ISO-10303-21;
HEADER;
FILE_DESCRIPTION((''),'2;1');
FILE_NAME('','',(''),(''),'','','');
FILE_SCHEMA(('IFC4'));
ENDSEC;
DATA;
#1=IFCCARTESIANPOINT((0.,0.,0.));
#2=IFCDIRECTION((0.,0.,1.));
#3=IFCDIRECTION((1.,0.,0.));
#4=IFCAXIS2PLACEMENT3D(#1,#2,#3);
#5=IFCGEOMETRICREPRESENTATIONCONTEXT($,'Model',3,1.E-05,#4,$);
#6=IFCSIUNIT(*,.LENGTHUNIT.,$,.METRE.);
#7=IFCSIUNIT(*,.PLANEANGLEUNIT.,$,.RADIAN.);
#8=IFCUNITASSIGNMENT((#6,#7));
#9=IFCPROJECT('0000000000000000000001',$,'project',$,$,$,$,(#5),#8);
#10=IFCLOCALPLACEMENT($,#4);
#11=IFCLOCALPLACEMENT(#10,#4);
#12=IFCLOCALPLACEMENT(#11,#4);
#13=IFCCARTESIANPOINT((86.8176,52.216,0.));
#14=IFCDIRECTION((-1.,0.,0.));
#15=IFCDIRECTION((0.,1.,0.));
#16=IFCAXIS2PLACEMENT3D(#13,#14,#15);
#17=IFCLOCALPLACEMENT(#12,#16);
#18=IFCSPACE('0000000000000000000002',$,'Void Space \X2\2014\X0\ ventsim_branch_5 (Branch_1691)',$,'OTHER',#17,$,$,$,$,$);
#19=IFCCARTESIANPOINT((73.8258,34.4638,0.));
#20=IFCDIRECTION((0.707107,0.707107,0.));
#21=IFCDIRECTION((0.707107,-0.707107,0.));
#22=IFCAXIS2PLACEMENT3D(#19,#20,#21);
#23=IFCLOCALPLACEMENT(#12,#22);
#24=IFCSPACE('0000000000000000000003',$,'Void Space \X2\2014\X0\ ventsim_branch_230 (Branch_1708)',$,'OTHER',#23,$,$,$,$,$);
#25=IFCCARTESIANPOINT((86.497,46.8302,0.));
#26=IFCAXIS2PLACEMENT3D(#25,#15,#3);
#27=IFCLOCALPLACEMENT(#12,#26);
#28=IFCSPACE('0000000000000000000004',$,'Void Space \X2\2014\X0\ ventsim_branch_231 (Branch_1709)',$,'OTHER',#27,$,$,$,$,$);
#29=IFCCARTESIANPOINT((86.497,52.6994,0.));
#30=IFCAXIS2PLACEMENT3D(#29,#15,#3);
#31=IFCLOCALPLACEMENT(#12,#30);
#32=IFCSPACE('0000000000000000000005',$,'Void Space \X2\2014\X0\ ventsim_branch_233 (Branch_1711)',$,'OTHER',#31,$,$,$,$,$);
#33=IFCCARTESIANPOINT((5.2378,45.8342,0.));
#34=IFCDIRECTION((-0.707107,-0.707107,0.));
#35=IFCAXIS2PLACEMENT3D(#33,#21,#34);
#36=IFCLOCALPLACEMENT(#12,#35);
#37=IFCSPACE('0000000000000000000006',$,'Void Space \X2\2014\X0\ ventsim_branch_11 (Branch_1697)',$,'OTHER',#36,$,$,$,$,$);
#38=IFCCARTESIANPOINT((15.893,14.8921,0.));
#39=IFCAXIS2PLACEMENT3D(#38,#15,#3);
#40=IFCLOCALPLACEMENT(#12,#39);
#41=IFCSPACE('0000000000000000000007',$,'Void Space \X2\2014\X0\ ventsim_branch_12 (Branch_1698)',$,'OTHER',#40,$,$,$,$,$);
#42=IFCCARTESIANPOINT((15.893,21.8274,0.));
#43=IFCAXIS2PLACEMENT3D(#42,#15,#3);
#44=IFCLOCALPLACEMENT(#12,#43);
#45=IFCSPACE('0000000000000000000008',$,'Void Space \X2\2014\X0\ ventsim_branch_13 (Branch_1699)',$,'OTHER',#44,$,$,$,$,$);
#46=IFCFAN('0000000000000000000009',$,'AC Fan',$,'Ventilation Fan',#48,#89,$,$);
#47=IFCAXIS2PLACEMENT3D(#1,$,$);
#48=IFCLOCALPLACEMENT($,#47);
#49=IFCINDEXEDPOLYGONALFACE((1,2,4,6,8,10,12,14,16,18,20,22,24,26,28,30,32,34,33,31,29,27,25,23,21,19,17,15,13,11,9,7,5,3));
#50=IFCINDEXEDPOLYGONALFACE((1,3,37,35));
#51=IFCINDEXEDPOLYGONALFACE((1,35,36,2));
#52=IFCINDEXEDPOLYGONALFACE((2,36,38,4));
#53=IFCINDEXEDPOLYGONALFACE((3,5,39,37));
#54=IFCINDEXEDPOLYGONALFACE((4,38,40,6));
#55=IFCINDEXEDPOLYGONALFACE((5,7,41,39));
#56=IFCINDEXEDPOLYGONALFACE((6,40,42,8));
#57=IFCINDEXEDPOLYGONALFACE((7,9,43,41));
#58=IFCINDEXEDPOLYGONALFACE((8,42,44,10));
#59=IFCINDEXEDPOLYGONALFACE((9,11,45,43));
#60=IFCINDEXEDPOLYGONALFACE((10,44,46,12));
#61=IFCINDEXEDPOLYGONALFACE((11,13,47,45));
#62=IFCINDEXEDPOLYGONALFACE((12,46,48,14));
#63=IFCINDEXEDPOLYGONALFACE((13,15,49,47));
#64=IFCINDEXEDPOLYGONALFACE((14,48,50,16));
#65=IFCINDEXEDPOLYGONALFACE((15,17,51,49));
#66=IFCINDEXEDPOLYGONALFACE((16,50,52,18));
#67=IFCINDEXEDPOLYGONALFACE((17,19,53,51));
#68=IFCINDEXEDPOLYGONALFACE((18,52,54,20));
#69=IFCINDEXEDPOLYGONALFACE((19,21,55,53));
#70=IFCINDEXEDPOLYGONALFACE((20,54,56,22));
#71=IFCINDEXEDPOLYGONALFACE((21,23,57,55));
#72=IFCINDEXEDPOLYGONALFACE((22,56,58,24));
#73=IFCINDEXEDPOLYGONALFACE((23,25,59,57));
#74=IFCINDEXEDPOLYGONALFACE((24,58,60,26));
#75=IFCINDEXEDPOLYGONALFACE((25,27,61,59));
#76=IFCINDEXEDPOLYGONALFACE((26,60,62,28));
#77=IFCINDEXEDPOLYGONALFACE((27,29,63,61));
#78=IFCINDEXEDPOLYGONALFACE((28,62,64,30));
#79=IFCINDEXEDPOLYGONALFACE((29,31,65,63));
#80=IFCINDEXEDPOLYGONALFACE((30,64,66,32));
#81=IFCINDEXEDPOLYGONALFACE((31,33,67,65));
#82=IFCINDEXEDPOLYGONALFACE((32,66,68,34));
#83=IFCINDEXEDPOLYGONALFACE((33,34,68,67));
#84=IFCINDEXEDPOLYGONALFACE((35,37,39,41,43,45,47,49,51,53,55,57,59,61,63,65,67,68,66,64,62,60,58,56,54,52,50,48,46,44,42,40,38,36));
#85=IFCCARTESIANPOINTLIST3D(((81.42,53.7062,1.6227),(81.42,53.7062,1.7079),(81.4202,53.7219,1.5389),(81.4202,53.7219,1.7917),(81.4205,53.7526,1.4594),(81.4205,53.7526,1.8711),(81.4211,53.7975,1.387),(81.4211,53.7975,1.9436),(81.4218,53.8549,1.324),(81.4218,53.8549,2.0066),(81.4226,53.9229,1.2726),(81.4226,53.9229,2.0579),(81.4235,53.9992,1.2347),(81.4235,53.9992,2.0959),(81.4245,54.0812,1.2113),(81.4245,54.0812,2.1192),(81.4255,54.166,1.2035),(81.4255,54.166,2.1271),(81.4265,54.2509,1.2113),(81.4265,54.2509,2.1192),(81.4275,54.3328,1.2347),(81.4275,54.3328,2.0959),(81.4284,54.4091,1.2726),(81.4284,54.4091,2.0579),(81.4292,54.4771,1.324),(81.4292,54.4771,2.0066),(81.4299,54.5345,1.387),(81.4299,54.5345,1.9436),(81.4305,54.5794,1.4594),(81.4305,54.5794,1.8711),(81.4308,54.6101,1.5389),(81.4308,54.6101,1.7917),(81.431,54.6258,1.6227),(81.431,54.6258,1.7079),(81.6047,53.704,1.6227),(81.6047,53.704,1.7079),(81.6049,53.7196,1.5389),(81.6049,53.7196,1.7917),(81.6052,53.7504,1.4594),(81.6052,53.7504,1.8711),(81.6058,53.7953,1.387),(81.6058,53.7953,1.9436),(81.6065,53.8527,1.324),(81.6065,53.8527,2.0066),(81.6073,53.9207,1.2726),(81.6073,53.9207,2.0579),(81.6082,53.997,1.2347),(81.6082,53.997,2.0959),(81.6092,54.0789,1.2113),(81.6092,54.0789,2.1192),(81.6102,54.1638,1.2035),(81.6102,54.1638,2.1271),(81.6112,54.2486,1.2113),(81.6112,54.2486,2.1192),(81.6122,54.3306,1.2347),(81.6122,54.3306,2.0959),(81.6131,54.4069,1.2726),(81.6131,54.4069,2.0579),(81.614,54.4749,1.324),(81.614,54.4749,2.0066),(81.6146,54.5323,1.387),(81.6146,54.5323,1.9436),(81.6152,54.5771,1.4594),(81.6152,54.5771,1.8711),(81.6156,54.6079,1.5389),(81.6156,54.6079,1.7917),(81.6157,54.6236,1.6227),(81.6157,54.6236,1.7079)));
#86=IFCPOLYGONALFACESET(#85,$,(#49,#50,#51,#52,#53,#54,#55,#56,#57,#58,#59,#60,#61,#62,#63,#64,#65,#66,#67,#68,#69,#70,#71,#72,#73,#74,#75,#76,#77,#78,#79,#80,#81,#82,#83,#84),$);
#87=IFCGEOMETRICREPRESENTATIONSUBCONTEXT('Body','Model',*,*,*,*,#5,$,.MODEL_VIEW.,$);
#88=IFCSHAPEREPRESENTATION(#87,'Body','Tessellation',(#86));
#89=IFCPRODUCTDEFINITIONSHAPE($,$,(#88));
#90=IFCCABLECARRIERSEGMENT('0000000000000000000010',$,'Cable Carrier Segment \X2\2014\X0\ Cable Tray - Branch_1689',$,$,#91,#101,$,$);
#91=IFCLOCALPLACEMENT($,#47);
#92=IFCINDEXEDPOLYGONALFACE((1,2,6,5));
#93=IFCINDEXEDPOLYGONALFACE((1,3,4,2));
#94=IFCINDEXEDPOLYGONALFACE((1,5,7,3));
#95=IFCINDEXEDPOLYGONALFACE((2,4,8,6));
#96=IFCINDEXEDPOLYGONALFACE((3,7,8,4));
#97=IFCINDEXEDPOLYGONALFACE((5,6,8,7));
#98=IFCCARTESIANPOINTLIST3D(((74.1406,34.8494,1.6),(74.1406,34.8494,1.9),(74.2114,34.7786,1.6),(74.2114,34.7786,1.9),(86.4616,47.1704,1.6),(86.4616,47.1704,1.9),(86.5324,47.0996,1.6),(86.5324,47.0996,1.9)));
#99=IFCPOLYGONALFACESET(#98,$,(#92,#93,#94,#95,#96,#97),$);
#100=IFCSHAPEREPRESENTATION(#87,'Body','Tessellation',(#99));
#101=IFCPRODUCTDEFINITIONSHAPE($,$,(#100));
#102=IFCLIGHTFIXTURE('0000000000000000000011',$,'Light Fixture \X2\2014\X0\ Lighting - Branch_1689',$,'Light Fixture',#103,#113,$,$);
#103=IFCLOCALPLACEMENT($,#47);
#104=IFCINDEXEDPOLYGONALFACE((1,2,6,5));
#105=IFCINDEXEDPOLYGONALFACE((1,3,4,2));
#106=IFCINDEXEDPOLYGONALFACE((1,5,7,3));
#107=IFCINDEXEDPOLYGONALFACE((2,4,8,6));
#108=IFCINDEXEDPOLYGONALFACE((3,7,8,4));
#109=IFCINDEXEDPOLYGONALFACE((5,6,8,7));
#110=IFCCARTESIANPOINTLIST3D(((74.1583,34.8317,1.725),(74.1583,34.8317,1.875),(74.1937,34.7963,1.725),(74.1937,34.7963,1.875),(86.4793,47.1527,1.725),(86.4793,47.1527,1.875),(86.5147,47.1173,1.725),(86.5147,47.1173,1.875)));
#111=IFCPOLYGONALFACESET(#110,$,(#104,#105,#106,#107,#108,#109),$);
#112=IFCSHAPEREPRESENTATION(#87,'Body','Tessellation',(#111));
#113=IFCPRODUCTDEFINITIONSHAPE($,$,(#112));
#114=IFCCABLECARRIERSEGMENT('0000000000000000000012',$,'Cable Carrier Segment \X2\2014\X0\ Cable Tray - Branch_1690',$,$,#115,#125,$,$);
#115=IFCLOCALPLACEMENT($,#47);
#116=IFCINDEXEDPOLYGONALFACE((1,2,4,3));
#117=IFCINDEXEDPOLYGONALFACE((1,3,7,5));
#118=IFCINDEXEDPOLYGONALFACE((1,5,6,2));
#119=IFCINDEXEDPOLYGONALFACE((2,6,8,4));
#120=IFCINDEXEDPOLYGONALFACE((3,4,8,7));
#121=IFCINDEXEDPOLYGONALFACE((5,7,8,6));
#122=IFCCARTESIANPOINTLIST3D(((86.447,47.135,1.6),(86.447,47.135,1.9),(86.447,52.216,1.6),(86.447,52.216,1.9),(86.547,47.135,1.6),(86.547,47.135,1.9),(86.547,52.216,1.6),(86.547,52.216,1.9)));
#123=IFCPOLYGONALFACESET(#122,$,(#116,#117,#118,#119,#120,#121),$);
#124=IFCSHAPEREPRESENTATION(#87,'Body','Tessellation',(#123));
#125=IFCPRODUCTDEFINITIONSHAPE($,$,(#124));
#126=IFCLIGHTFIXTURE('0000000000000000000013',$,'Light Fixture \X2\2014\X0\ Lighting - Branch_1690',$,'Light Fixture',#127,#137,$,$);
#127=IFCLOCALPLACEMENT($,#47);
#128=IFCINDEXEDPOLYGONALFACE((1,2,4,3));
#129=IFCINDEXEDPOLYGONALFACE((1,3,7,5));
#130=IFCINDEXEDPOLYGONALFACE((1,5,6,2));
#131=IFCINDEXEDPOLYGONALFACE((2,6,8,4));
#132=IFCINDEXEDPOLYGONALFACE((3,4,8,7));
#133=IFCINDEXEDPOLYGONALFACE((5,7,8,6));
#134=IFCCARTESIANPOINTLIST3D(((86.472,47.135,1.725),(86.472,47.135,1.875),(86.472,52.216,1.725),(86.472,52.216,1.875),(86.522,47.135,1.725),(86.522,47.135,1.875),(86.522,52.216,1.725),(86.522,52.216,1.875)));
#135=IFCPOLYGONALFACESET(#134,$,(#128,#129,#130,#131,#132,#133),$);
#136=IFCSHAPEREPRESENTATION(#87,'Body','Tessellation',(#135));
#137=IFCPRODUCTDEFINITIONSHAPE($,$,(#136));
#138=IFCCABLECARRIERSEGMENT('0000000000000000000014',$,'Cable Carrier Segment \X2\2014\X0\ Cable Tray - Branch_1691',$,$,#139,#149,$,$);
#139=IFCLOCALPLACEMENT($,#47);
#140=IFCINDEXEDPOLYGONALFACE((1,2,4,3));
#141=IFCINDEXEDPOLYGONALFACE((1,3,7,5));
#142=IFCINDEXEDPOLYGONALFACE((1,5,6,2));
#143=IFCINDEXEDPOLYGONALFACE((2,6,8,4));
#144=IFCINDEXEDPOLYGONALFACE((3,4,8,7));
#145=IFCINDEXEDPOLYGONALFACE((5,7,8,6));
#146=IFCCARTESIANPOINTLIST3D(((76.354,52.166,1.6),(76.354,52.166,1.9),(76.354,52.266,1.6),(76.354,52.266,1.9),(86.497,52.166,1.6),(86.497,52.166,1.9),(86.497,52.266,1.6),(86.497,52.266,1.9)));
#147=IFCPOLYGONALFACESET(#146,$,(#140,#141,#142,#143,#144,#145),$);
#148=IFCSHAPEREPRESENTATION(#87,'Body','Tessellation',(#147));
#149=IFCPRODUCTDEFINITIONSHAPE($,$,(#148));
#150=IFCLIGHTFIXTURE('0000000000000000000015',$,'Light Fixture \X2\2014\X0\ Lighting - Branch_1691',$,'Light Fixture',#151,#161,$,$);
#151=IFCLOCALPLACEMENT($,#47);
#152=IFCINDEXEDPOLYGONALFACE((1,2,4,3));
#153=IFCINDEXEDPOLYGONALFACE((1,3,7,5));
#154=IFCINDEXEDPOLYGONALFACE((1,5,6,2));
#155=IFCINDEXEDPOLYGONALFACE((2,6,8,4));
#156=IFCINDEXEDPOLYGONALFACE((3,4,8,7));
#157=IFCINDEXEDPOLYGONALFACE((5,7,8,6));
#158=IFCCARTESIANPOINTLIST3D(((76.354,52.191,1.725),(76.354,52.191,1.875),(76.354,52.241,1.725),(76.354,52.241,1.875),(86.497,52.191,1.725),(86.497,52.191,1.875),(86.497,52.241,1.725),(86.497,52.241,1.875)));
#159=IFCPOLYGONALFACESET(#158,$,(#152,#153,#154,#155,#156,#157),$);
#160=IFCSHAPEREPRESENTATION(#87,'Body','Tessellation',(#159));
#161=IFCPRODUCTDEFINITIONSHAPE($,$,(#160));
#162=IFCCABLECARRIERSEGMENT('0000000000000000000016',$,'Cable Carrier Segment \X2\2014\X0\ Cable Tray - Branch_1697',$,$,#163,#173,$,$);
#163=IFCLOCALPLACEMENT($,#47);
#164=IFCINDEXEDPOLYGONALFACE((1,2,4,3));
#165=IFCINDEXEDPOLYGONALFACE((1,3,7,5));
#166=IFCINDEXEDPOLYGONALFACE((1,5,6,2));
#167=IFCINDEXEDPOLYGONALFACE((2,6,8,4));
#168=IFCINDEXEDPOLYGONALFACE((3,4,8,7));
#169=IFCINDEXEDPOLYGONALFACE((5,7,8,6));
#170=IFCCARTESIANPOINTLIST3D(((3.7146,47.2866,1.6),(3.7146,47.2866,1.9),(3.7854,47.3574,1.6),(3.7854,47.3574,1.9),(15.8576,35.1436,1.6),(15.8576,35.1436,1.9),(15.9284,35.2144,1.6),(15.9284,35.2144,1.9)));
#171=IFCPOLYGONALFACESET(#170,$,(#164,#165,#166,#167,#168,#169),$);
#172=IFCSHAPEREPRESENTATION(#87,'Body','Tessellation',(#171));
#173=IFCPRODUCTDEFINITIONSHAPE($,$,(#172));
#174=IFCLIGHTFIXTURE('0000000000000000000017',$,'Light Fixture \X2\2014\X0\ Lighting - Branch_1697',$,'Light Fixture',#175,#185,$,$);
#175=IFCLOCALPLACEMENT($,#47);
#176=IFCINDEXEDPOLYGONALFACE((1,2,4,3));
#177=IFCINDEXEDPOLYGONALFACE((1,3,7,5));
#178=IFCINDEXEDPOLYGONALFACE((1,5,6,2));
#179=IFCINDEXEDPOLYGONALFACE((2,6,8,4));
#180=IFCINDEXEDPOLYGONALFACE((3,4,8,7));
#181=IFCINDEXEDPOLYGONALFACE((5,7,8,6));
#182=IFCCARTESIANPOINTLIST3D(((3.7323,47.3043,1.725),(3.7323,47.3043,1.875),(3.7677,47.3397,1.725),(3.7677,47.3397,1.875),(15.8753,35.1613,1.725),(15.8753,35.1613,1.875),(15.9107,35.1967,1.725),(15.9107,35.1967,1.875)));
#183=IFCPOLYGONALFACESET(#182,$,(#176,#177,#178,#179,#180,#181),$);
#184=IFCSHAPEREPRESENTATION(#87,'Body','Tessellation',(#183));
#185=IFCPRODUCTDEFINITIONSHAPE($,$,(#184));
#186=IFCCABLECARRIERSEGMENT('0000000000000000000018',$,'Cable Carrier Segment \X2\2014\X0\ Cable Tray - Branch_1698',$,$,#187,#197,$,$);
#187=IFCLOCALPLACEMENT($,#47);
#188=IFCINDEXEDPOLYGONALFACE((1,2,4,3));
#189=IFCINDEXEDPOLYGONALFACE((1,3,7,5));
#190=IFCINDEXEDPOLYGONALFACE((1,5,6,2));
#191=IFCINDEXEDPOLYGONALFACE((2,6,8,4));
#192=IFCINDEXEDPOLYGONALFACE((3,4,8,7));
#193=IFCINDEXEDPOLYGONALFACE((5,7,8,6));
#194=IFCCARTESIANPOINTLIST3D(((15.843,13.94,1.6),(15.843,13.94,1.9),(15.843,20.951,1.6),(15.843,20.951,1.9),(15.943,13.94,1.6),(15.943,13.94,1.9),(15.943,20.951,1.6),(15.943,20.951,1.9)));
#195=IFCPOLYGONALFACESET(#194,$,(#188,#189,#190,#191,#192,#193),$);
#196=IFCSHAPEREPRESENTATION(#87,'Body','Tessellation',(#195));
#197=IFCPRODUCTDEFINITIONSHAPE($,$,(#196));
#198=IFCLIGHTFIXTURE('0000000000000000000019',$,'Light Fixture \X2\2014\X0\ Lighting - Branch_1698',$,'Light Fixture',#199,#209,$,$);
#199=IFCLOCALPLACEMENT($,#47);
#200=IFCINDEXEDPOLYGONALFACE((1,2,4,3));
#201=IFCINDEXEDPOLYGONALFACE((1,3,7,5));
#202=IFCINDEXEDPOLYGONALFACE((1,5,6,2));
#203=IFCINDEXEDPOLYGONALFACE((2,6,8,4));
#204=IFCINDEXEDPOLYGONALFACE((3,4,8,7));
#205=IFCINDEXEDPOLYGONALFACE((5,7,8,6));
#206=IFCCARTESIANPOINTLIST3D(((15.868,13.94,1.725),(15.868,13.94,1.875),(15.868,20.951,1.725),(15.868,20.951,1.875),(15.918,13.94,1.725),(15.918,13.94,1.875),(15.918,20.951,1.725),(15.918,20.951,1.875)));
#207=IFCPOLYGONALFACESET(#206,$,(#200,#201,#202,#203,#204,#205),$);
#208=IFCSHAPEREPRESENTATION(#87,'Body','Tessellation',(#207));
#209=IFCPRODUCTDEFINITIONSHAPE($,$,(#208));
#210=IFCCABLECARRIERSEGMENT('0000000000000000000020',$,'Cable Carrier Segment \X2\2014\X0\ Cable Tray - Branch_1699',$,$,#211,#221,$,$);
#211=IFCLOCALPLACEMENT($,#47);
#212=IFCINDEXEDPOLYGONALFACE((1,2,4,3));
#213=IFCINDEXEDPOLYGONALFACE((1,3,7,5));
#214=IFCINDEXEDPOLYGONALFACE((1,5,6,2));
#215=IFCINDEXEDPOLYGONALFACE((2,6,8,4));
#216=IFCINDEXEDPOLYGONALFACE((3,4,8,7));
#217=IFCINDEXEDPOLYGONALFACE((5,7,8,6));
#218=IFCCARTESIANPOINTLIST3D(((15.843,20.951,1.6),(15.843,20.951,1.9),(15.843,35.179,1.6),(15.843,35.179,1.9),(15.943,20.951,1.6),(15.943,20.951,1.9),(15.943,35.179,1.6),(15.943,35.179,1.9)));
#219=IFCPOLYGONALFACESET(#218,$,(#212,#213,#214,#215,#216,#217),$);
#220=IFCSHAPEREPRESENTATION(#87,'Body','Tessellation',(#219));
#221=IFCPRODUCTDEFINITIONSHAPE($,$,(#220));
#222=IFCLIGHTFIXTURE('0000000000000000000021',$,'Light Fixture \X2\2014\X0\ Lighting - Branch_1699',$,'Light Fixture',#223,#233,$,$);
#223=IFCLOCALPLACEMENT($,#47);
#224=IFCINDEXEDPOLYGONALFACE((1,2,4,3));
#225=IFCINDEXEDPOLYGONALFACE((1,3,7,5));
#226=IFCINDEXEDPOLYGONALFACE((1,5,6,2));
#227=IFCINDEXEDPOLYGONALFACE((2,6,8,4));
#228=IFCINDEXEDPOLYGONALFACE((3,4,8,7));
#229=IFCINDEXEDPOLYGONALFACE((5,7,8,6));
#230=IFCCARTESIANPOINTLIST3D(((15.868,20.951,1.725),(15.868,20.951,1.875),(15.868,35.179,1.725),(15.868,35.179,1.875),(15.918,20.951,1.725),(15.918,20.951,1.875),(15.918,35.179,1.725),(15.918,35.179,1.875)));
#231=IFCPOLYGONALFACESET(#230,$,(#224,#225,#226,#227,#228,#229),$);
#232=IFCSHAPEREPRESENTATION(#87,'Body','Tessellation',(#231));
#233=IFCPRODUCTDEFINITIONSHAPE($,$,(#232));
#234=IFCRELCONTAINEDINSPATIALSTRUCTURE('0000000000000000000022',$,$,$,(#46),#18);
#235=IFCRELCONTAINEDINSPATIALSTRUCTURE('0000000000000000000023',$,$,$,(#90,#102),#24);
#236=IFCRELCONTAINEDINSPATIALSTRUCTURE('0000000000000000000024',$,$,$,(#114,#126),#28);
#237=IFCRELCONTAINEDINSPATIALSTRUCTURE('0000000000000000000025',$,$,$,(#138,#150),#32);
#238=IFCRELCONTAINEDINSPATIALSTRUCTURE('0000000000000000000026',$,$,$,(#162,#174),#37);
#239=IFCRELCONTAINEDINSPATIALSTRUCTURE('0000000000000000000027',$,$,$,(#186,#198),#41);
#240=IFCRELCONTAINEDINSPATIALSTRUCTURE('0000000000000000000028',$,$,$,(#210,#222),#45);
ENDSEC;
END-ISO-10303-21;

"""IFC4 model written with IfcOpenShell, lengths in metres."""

from ifc_helpers import new_model, si_unit, frame, origin_with_axes, origin_2d_with_axis, place, context, subcontext, project, spatial, rectangle, circle, extrude, element, save


model = new_model("IFC4")

# Units and contexts
model_context = context("Model", 3, precision=1e-05, world=origin_with_axes())
body_context = subcontext(model_context, "Body", "Model", "MODEL_VIEW")
ifc_project = project(units=[si_unit("LENGTHUNIT", "METRE"), si_unit("PLANEANGLEUNIT", "RADIAN")], contexts=[model_context])

# Space
placement_1 = place(None, origin_with_axes())
placement_2 = place(placement_1, origin_with_axes())
placement_3 = place(placement_2, origin_with_axes())
space_1_placement = place(placement_3, frame((86.8176, 52.216, 0.0), z_axis=(-1.0, 0.0, 0.0), x_axis=(0.0, 1.0, 0.0)))
space_1 = spatial("IfcSpace", at=space_1_placement, Name="Void Space — ventsim_branch_5 (Branch_1691)", ObjectType="OTHER")

# Fan
fan_placement = place(placement_3, frame((81.4255, 54.166, 1.6653), z_axis=(0.999928, -0.012018, 0.0), x_axis=(0.0, 0.0, 1.0)))
element("IfcFan", 1, at=fan_placement, inside=space_1, Name="AC Fan", ObjectType="Ventilation Fan", context=body_context, shape_type="SweptSolid", body=[
    extrude(circle(Radius=0.4618, at=origin_2d_with_axis()), origin_with_axes(), (0.0, 0.0, 1.0), 0.1847),
])

# Shared definitions
space_2_placement = place(placement_3, frame((73.8258, 34.4638, 0.0), z_axis=(0.707107, 0.707107, 0.0), x_axis=(0.707107, -0.707107, 0.0)))
space_2 = spatial("IfcSpace", at=space_2_placement, Name="Void Space — ventsim_branch_230 (Branch_1708)", ObjectType="OTHER")

# Cable carrier segment
cable_carrier_segment_1_placement = place(placement_3, frame((74.176, 34.814, 1.75), z_axis=(0.707107, 0.707107, 0.0), x_axis=(0.0, 0.0, 1.0)))
element("IfcCableCarrierSegment", 2, at=cable_carrier_segment_1_placement, inside=space_2, Name="Cable Carrier Segment — Cable Tray - Branch_1689", context=body_context, shape_type="SweptSolid", body=[
    extrude(rectangle(XDim=0.3, YDim=0.1, at=origin_2d_with_axis()), origin_with_axes(), (0.0, 0.0, 1.0), 17.4245),
])

# Light fixture
light_fixture_1_placement = place(placement_3, frame((74.176, 34.814, 1.8), z_axis=(0.707107, 0.707107, 0.0), x_axis=(0.0, 0.0, 1.0)))
element("IfcLightFixture", 3, at=light_fixture_1_placement, inside=space_2, Name="Light Fixture — Lighting - Branch_1689", ObjectType="Light Fixture", context=body_context, shape_type="SweptSolid", body=[
    extrude(rectangle(XDim=0.15, YDim=0.05, at=origin_2d_with_axis()), origin_with_axes(), (0.0, 0.0, 1.0), 17.4245),
])

# Shared definitions
space_3_placement = place(placement_3, frame((86.497, 46.8302, 0.0), z_axis=(0.0, 1.0, 0.0), x_axis=(1.0, 0.0, 0.0)))
space_3 = spatial("IfcSpace", at=space_3_placement, Name="Void Space — ventsim_branch_231 (Branch_1709)", ObjectType="OTHER")

# Cable carrier segment
cable_carrier_segment_2_placement = place(placement_3, frame((86.497, 47.135, 1.75), z_axis=(0.0, 1.0, 0.0), x_axis=(0.0, 0.0, 1.0)))
element("IfcCableCarrierSegment", 4, at=cable_carrier_segment_2_placement, inside=space_3, Name="Cable Carrier Segment — Cable Tray - Branch_1690", context=body_context, shape_type="SweptSolid", body=[
    extrude(rectangle(XDim=0.3, YDim=0.1, at=origin_2d_with_axis()), origin_with_axes(), (0.0, 0.0, 1.0), 5.081),
])

# Light fixture
light_fixture_2_placement = place(placement_3, frame((86.497, 47.135, 1.8), z_axis=(0.0, 1.0, 0.0), x_axis=(0.0, 0.0, 1.0)))
element("IfcLightFixture", 5, at=light_fixture_2_placement, inside=space_3, Name="Light Fixture — Lighting - Branch_1690", ObjectType="Light Fixture", context=body_context, shape_type="SweptSolid", body=[
    extrude(rectangle(XDim=0.15, YDim=0.05, at=origin_2d_with_axis()), origin_with_axes(), (0.0, 0.0, 1.0), 5.081),
])

# Shared definitions
space_4_placement = place(placement_3, frame((86.497, 52.6994, 0.0), z_axis=(0.0, 1.0, 0.0), x_axis=(1.0, 0.0, 0.0)))
space_4 = spatial("IfcSpace", at=space_4_placement, Name="Void Space — ventsim_branch_233 (Branch_1711)", ObjectType="OTHER")

# Cable carrier segment
cable_carrier_segment_3_placement = place(placement_3, frame((86.497, 52.216, 1.75), z_axis=(-1.0, 0.0, 0.0), x_axis=(0.0, 0.0, 1.0)))
element("IfcCableCarrierSegment", 6, at=cable_carrier_segment_3_placement, inside=space_4, Name="Cable Carrier Segment — Cable Tray - Branch_1691", context=body_context, shape_type="SweptSolid", body=[
    extrude(rectangle(XDim=0.3, YDim=0.1, at=origin_2d_with_axis()), origin_with_axes(), (0.0, 0.0, 1.0), 10.143),
])

# Light fixture
light_fixture_3_placement = place(placement_3, frame((86.497, 52.216, 1.8), z_axis=(-1.0, 0.0, 0.0), x_axis=(0.0, 0.0, 1.0)))
element("IfcLightFixture", 7, at=light_fixture_3_placement, inside=space_4, Name="Light Fixture — Lighting - Branch_1691", ObjectType="Light Fixture", context=body_context, shape_type="SweptSolid", body=[
    extrude(rectangle(XDim=0.15, YDim=0.05, at=origin_2d_with_axis()), origin_with_axes(), (0.0, 0.0, 1.0), 10.143),
])

# Shared definitions
space_5_placement = place(placement_3, frame((5.2378, 45.8342, 0.0), z_axis=(0.707107, -0.707107, 0.0), x_axis=(-0.707107, -0.707107, 0.0)))
space_5 = spatial("IfcSpace", at=space_5_placement, Name="Void Space — ventsim_branch_11 (Branch_1697)", ObjectType="OTHER")

# Cable carrier segment
cable_carrier_segment_4_placement = place(placement_3, frame((3.75, 47.322, 1.75), z_axis=(0.707107, -0.707107, 0.0), x_axis=(0.0, 0.0, 1.0)))
element("IfcCableCarrierSegment", 8, at=cable_carrier_segment_4_placement, inside=space_5, Name="Cable Carrier Segment — Cable Tray - Branch_1697", context=body_context, shape_type="SweptSolid", body=[
    extrude(rectangle(XDim=0.3, YDim=0.1, at=origin_2d_with_axis()), origin_with_axes(), (0.0, 0.0, 1.0), 17.1728),
])

# Light fixture
light_fixture_4_placement = place(placement_3, frame((3.75, 47.322, 1.8), z_axis=(0.707107, -0.707107, 0.0), x_axis=(0.0, 0.0, 1.0)))
element("IfcLightFixture", 9, at=light_fixture_4_placement, inside=space_5, Name="Light Fixture — Lighting - Branch_1697", ObjectType="Light Fixture", context=body_context, shape_type="SweptSolid", body=[
    extrude(rectangle(XDim=0.15, YDim=0.05, at=origin_2d_with_axis()), origin_with_axes(), (0.0, 0.0, 1.0), 17.1728),
])

# Shared definitions
space_6_placement = place(placement_3, frame((15.893, 14.8921, 0.0), z_axis=(0.0, 1.0, 0.0), x_axis=(1.0, 0.0, 0.0)))
space_6 = spatial("IfcSpace", at=space_6_placement, Name="Void Space — ventsim_branch_12 (Branch_1698)", ObjectType="OTHER")

# Cable carrier segment
cable_carrier_segment_5_placement = place(placement_3, frame((15.893, 13.94, 1.75), z_axis=(0.0, 1.0, 0.0), x_axis=(0.0, 0.0, 1.0)))
element("IfcCableCarrierSegment", 10, at=cable_carrier_segment_5_placement, inside=space_6, Name="Cable Carrier Segment — Cable Tray - Branch_1698", context=body_context, shape_type="SweptSolid", body=[
    extrude(rectangle(XDim=0.3, YDim=0.1, at=origin_2d_with_axis()), origin_with_axes(), (0.0, 0.0, 1.0), 7.011),
])

# Light fixture
light_fixture_5_placement = place(placement_3, frame((15.893, 13.94, 1.8), z_axis=(0.0, 1.0, 0.0), x_axis=(0.0, 0.0, 1.0)))
element("IfcLightFixture", 11, at=light_fixture_5_placement, inside=space_6, Name="Light Fixture — Lighting - Branch_1698", ObjectType="Light Fixture", context=body_context, shape_type="SweptSolid", body=[
    extrude(rectangle(XDim=0.15, YDim=0.05, at=origin_2d_with_axis()), origin_with_axes(), (0.0, 0.0, 1.0), 7.011),
])

# Shared definitions
space_7_placement = place(placement_3, frame((15.893, 21.8274, 0.0), z_axis=(0.0, 1.0, 0.0), x_axis=(1.0, 0.0, 0.0)))
space_7 = spatial("IfcSpace", at=space_7_placement, Name="Void Space — ventsim_branch_13 (Branch_1699)", ObjectType="OTHER")

# Cable carrier segment
cable_carrier_segment_6_placement = place(placement_3, frame((15.893, 20.951, 1.75), z_axis=(0.0, 1.0, 0.0), x_axis=(0.0, 0.0, 1.0)))
element("IfcCableCarrierSegment", 12, at=cable_carrier_segment_6_placement, inside=space_7, Name="Cable Carrier Segment — Cable Tray - Branch_1699", context=body_context, shape_type="SweptSolid", body=[
    extrude(rectangle(XDim=0.3, YDim=0.1, at=origin_2d_with_axis()), origin_with_axes(), (0.0, 0.0, 1.0), 14.228),
])

# Light fixture
light_fixture_6_placement = place(placement_3, frame((15.893, 20.951, 1.8), z_axis=(0.0, 1.0, 0.0), x_axis=(0.0, 0.0, 1.0)))
element("IfcLightFixture", 13, at=light_fixture_6_placement, inside=space_7, Name="Light Fixture — Lighting - Branch_1699", ObjectType="Light Fixture", context=body_context, shape_type="SweptSolid", body=[
    extrude(rectangle(XDim=0.15, YDim=0.05, at=origin_2d_with_axis()), origin_with_axes(), (0.0, 0.0, 1.0), 14.228),
])

save(model, "model.ifc")
